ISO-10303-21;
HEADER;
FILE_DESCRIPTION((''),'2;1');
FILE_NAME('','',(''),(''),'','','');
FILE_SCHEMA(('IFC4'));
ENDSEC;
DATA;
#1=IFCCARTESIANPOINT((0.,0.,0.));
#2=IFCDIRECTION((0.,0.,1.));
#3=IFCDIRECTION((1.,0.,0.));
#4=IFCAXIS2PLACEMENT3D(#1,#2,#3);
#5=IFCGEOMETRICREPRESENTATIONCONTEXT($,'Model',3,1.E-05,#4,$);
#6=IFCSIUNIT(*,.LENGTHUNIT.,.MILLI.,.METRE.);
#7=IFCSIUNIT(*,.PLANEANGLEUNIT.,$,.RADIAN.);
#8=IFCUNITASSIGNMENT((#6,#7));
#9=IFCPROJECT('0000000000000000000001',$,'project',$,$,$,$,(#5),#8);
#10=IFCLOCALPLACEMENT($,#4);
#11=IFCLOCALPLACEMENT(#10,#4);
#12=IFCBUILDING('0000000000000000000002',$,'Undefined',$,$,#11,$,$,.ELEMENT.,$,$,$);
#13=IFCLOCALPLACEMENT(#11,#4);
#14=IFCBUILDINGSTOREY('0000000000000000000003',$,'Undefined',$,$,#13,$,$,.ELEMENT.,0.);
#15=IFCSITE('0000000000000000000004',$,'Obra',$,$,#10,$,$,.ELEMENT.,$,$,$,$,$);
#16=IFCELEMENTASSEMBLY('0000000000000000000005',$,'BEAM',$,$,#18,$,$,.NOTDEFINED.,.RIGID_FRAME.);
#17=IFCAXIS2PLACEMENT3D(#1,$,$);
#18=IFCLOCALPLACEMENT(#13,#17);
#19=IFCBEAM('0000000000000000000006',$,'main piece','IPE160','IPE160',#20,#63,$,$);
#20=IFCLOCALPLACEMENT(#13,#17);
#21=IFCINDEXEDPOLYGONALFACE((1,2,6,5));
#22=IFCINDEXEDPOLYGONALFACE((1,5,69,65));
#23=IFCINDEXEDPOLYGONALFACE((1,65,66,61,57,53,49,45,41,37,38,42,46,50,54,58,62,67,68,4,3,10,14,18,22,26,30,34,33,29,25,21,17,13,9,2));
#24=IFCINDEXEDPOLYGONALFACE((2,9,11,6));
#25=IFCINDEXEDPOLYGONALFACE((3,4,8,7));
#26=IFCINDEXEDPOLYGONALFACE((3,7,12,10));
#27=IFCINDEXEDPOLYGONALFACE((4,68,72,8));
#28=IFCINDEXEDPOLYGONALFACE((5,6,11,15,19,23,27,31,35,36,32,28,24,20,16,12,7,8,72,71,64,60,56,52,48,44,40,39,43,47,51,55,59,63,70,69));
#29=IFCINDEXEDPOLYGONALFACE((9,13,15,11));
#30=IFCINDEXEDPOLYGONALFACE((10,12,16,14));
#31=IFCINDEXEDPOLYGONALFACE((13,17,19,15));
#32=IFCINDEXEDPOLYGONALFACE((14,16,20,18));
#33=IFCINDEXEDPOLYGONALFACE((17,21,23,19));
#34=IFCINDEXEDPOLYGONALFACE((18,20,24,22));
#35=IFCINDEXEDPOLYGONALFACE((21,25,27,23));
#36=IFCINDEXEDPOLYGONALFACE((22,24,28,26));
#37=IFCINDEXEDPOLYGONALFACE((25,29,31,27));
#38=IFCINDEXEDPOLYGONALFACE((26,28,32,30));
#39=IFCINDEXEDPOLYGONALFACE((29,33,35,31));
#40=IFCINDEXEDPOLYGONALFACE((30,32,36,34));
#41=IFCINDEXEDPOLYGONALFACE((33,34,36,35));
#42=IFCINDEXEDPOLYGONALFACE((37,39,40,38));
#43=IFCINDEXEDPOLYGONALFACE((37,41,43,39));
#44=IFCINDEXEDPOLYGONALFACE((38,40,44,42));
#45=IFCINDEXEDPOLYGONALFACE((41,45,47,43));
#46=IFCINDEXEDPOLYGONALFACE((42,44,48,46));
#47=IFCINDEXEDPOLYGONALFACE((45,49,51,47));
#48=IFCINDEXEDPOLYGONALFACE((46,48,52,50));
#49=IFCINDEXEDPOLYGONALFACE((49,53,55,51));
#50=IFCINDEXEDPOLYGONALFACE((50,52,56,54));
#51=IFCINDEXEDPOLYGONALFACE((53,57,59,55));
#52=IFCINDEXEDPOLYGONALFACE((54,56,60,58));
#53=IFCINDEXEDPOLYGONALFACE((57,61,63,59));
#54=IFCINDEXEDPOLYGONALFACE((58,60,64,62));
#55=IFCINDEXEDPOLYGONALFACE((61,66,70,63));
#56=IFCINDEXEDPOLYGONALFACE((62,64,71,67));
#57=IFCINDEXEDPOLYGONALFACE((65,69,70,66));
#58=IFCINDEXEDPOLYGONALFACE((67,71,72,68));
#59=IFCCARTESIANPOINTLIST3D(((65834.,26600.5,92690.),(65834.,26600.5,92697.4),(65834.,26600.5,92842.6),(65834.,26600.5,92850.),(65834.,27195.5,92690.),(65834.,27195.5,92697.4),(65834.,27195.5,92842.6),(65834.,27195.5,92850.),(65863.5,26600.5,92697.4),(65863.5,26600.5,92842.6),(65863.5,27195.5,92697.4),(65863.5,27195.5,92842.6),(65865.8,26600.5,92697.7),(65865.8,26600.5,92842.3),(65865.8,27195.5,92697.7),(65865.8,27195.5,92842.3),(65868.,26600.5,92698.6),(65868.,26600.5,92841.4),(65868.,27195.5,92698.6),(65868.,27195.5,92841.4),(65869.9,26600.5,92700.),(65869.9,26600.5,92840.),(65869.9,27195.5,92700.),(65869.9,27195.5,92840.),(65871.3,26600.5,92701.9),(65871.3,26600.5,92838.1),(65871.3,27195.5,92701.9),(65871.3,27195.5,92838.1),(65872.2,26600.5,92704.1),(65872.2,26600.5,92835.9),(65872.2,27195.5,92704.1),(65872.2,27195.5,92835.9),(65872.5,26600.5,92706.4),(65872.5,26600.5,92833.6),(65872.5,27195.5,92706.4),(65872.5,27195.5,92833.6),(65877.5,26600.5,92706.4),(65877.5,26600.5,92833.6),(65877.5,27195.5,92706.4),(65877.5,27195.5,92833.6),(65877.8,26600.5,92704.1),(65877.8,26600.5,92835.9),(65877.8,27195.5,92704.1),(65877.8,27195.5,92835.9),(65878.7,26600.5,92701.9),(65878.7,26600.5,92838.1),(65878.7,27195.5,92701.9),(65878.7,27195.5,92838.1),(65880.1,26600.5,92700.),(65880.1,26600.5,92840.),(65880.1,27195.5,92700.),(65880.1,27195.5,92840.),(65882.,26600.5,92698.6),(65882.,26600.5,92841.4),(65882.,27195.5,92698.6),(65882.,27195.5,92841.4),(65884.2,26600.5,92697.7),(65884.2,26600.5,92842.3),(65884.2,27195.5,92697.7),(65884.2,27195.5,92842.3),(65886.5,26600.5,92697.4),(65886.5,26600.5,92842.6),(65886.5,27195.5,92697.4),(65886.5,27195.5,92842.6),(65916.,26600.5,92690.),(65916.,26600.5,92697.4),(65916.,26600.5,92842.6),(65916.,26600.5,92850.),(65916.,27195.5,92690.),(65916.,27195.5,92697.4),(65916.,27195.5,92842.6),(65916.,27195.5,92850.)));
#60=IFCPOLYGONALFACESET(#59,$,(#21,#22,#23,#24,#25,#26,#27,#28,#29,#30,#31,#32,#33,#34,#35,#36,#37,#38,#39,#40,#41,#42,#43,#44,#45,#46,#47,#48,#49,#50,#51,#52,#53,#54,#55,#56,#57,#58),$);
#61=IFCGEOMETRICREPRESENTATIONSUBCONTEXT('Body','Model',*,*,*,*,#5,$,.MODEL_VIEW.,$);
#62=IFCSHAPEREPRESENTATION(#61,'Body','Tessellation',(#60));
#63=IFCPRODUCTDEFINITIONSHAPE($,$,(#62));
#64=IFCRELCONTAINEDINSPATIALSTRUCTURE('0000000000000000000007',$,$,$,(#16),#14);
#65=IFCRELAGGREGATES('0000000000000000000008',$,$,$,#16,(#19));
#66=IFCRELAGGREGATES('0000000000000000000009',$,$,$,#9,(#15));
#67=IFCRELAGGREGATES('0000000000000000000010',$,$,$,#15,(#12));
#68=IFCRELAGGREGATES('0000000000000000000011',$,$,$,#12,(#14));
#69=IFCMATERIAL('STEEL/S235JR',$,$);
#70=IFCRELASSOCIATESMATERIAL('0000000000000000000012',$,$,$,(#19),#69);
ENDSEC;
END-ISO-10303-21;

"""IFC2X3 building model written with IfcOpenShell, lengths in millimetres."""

from ifc_helpers import new_model, si_unit, frame, origin_with_axes, origin_2d_with_axis, place, context, subcontext, project, spatial, i_section, extrude, material, element, aggregate, save


model = new_model("IFC2X3")

# Units and contexts
model_context = context("Model", 3, precision=1e-05, world=origin_with_axes())
body_context = subcontext(model_context, "Body", "Model", "MODEL_VIEW")
ifc_project = project(units=[si_unit("LENGTHUNIT", "METRE", prefix="MILLI"), si_unit("PLANEANGLEUNIT", "RADIAN")], contexts=[model_context])

# Site, building, storey
site_placement = place(None, origin_with_axes())
site = spatial("IfcSite", under=ifc_project, at=site_placement, Name="Obra", CompositionType="ELEMENT")
building_placement = place(site_placement, origin_with_axes())
building = spatial("IfcBuilding", under=site, at=building_placement, Name="Undefined", CompositionType="ELEMENT")
storey_placement = place(building_placement, origin_with_axes())
storey = spatial("IfcBuildingStorey", under=building, at=storey_placement, Name="Undefined", CompositionType="ELEMENT", Elevation=0.0)

# Element assembly, beam
assembly_1_placement = place(storey_placement, origin_with_axes())
assembly_1 = element("IfcElementAssembly", 1, at=assembly_1_placement, inside=storey, Name="BEAM", AssemblyPlace="NOTDEFINED", PredefinedType="RIGID_FRAME")
ifc_material_1 = material(Name="STEEL/S235JR")
beam_placement = place(assembly_1_placement, frame((65875.0, 26600.5, 92770.0), z_axis=(0.0, 0.0, 1.0), x_axis=(0.0, 1.0, 0.0)))
beam = element("IfcBeam", 2, at=beam_placement, material=ifc_material_1, Name="main piece", Description="IPE160", ObjectType="IPE160", context=body_context, shape_type="SweptSolid", body=[
    extrude(i_section(OverallWidth=82.0, OverallDepth=160.0, WebThickness=5.0, FlangeThickness=7.4, FilletRadius=9.0, at=origin_2d_with_axis()), frame((595.1, 0.0, 0.0), z_axis=(-1.0, 0.0, 0.0), x_axis=(0.0, -1.0, 0.0)), (0.0, 0.0, 1.0), 595.0),
])
aggregate(assembly_1, [beam])

save(model, "model.ifc")
